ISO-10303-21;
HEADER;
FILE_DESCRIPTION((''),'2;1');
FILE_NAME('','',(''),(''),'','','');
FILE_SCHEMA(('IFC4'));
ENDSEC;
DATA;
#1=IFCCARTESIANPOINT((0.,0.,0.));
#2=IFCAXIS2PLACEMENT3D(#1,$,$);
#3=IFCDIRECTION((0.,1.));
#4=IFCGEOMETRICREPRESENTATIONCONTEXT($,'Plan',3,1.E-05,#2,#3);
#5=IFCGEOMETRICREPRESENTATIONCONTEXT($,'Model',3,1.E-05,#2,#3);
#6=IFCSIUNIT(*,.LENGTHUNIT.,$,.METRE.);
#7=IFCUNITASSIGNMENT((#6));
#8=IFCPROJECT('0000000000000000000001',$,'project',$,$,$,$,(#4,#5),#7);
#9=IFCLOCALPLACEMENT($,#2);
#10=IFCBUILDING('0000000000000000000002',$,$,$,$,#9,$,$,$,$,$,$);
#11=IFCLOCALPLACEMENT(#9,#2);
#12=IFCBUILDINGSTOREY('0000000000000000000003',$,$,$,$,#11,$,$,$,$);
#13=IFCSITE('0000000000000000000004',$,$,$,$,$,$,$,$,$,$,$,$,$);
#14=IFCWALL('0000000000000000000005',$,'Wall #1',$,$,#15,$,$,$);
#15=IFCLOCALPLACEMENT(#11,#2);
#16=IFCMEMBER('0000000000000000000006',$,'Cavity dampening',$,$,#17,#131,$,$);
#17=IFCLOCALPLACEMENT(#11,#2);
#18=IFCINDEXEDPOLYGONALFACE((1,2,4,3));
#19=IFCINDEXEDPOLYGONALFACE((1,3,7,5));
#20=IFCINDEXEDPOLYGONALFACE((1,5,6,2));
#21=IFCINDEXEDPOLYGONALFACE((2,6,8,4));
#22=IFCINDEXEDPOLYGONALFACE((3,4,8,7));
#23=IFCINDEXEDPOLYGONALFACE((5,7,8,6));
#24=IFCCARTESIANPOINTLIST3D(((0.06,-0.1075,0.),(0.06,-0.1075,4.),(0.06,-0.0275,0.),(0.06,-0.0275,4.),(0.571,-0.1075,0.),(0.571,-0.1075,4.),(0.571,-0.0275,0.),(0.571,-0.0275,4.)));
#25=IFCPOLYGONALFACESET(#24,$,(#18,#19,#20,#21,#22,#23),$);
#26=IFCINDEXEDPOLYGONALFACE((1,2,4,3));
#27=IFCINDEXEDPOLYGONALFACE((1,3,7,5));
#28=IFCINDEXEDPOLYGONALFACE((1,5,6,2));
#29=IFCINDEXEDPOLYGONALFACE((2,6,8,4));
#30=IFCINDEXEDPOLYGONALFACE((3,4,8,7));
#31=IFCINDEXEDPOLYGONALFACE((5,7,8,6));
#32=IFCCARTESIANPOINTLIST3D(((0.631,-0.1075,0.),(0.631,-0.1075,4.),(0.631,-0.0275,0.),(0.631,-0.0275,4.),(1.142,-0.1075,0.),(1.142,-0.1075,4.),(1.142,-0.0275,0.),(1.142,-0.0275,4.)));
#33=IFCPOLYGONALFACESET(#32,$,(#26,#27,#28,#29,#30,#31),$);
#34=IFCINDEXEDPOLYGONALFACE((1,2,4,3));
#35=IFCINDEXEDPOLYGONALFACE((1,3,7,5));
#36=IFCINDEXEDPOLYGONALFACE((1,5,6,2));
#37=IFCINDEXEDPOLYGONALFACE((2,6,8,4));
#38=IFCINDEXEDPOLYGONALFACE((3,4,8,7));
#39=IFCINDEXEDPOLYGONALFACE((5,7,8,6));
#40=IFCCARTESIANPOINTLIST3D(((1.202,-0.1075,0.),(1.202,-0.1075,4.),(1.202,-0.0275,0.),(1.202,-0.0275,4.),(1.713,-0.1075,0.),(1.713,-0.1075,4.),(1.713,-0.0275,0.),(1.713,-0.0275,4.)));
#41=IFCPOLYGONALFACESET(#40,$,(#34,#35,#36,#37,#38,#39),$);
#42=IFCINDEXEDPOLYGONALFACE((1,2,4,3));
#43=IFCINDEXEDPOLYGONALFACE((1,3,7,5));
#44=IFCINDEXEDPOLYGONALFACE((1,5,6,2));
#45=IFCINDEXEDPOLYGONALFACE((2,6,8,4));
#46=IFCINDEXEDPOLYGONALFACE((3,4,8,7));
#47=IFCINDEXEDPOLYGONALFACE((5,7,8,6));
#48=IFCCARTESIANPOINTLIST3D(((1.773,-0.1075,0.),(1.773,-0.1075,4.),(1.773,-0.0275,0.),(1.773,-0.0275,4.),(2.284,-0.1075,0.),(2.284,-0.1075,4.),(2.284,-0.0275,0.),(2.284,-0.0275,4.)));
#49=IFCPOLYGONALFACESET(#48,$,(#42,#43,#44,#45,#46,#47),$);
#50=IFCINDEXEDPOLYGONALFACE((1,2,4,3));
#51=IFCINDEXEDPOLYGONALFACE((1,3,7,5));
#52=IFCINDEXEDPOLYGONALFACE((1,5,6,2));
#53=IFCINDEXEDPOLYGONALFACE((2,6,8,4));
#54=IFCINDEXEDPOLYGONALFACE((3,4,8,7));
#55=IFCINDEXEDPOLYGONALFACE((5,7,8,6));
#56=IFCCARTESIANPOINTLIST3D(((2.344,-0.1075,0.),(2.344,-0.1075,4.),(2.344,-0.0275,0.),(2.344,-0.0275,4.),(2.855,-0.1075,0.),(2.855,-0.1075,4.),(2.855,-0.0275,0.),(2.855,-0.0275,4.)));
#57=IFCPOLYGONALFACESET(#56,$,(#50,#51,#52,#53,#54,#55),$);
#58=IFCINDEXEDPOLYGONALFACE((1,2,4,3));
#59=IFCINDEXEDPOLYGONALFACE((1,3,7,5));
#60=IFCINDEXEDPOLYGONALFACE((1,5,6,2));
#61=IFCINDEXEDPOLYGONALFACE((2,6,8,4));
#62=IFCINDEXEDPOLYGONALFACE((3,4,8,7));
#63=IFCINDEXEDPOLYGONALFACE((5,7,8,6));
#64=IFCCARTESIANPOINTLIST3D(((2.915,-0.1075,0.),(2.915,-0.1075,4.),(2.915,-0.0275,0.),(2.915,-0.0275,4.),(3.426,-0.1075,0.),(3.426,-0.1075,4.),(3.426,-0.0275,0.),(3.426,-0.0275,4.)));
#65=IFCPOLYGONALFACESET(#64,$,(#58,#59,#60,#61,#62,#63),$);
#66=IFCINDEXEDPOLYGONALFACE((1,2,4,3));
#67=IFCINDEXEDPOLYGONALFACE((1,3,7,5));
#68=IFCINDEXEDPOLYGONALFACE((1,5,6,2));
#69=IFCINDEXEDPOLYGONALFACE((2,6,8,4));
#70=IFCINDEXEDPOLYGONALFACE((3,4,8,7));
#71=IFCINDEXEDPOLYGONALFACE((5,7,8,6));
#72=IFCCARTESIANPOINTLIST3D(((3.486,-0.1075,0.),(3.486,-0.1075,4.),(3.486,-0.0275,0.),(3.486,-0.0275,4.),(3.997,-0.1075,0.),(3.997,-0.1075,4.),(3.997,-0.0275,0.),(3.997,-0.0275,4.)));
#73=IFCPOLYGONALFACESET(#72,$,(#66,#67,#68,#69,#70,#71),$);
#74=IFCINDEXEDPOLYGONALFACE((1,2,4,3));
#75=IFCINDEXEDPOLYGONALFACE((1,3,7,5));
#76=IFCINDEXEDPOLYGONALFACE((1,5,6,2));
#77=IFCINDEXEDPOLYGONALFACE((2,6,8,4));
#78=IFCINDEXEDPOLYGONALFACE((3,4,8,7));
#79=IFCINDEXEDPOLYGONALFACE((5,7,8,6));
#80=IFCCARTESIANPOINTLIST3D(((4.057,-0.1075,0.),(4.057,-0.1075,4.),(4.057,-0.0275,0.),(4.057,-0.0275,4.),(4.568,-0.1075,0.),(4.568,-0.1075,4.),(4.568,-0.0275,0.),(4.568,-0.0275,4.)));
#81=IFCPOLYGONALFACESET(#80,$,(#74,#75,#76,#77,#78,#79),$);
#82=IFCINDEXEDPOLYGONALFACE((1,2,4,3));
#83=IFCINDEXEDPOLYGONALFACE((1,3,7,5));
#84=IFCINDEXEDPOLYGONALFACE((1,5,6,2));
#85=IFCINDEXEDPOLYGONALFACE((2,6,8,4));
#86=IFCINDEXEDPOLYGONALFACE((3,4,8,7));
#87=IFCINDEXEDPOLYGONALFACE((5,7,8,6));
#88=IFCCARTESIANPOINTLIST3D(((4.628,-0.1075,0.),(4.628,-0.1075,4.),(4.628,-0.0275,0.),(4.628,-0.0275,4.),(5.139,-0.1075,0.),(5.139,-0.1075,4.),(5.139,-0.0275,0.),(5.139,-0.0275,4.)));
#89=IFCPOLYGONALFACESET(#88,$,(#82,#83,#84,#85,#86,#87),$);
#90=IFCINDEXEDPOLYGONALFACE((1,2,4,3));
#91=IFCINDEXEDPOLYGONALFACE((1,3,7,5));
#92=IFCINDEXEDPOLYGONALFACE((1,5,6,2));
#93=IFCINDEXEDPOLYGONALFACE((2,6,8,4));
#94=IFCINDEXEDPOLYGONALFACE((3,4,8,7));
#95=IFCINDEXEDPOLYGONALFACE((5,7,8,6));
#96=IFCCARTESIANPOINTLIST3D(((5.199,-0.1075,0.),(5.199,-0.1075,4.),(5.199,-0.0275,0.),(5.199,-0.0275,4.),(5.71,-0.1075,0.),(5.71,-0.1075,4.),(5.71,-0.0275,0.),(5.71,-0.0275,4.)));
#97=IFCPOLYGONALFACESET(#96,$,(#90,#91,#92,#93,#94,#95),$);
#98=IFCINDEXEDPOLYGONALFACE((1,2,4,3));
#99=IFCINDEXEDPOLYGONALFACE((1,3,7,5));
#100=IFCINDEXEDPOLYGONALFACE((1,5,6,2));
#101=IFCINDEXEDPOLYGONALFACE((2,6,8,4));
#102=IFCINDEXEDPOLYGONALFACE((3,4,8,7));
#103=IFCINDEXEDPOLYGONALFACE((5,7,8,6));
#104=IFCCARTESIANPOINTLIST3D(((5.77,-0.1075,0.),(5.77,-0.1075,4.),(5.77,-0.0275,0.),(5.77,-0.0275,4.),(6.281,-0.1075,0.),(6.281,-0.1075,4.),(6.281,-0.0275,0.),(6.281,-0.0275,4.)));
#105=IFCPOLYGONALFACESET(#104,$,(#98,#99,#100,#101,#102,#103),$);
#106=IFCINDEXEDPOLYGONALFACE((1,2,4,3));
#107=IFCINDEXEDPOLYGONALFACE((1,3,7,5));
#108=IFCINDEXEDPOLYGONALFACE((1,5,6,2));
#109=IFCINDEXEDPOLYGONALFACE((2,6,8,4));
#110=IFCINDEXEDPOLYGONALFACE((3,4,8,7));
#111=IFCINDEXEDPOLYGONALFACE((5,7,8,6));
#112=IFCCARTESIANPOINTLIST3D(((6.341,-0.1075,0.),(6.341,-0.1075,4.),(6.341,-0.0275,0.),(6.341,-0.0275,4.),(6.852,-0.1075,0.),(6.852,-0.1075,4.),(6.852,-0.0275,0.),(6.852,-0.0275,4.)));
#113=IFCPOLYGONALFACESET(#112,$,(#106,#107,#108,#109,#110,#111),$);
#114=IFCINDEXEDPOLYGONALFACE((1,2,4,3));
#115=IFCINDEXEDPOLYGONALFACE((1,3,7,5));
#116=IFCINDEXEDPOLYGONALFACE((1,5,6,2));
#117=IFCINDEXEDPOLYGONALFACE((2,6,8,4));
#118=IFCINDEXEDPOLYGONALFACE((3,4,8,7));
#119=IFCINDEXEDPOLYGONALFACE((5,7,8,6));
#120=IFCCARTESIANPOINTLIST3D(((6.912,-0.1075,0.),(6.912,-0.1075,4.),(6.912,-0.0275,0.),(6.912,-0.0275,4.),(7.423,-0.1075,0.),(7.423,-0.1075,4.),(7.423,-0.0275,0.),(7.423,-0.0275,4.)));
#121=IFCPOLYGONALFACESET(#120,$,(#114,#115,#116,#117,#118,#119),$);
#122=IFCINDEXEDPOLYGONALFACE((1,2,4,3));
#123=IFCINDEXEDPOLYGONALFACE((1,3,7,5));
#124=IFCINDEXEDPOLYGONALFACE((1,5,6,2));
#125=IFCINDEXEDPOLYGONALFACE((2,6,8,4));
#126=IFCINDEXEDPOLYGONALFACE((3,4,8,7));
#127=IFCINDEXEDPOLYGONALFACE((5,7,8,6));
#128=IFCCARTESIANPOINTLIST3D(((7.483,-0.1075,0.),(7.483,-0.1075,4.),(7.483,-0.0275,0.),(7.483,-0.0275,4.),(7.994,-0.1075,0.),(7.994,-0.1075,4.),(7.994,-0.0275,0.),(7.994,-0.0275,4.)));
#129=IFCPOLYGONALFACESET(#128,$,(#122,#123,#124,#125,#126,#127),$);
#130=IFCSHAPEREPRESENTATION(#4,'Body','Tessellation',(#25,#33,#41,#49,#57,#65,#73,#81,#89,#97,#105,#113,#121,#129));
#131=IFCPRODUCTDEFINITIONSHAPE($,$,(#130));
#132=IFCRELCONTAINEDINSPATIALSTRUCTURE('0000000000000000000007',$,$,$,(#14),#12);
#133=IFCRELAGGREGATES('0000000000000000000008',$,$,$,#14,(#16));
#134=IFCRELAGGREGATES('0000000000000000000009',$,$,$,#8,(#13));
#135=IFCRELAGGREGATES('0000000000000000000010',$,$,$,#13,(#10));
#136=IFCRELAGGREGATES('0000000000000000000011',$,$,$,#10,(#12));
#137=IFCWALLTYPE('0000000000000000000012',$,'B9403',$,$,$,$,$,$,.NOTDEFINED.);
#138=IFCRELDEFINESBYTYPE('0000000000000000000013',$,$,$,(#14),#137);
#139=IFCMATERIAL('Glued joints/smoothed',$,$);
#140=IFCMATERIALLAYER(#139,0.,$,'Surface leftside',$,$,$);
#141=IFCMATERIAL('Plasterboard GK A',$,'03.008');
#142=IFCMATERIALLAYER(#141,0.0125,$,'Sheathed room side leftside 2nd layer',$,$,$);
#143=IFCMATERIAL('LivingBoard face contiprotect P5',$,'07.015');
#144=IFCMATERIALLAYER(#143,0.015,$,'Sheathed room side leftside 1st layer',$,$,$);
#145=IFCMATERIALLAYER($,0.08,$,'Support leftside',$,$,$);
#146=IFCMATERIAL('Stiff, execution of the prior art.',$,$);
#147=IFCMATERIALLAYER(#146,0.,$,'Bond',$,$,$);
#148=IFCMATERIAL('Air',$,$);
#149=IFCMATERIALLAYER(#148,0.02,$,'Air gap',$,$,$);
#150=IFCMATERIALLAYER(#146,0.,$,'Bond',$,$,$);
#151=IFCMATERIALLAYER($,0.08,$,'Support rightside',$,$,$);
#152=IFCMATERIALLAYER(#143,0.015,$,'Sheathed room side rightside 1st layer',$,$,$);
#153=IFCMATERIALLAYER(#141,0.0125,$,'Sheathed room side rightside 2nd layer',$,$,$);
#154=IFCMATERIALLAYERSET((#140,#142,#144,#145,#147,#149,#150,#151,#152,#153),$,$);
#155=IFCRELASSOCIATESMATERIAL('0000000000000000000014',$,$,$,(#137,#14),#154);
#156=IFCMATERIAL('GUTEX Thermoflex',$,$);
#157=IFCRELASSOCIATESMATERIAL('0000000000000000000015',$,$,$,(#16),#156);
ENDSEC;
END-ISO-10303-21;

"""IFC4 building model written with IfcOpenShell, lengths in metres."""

from ifc_helpers import new_model, si_unit, direction, frame, frame_2d, origin, place, context, project, spatial, rectangle, extrude, material, layer, layer_set, type_object, element, aggregate, save


model = new_model("IFC4")

# Units and contexts
plan_context = context("Plan", 3, precision=1e-05, world=origin(), true_north=direction((0.0, 1.0)))
model_context = context("Model", 3, precision=1e-05, world=origin(), true_north=direction((0.0, 1.0)))
ifc_project = project(units=[si_unit("LENGTHUNIT", "METRE")], contexts=[plan_context, model_context])

# Site, building, storey
site = spatial("IfcSite", under=ifc_project)
building_placement = place(None, origin())
building = spatial("IfcBuilding", under=site, at=building_placement)
storey_placement = place(building_placement, origin())
storey = spatial("IfcBuildingStorey", under=building, at=storey_placement)

# Wall, member
ifc_material_1 = material(Name="Glued joints/smoothed")
ifc_layer_1 = layer(ifc_material_1, 0.0, Name="Surface leftside")
ifc_material_2 = material(Name="Plasterboard GK A", Category="03.008")
ifc_layer_2 = layer(ifc_material_2, 0.0125, Name="Sheathed room side leftside 2nd layer")
ifc_material_3 = material(Name="LivingBoard face contiprotect P5", Category="07.015")
ifc_layer_3 = layer(ifc_material_3, 0.015, Name="Sheathed room side leftside 1st layer")
ifc_layer_4 = layer(None, 0.08, Name="Support leftside")
ifc_material_4 = material(Name="Stiff, execution of the prior art.")
ifc_layer_5 = layer(ifc_material_4, 0.0, Name="Bond")
ifc_material_5 = material(Name="Air")
ifc_layer_6 = layer(ifc_material_5, 0.02, Name="Air gap")
ifc_layer_7 = layer(ifc_material_4, 0.0, Name="Bond")
ifc_layer_8 = layer(None, 0.08, Name="Support rightside")
ifc_layer_9 = layer(ifc_material_3, 0.015, Name="Sheathed room side rightside 1st layer")
ifc_layer_10 = layer(ifc_material_2, 0.0125, Name="Sheathed room side rightside 2nd layer")
ifc_layer_set = layer_set([ifc_layer_1, ifc_layer_2, ifc_layer_3, ifc_layer_4, ifc_layer_5, ifc_layer_6, ifc_layer_7, ifc_layer_8, ifc_layer_9, ifc_layer_10])
wall_type = type_object("IfcWallType", Name="B9403", PredefinedType="NOTDEFINED", material=ifc_layer_set)
wall_placement = place(None, frame((0.0, 0.0, 0.0), z_axis=(0.0, -1.0, 0.0), x_axis=(1.0, 0.0, 0.0)))
wall = element("IfcWall", 1, at=wall_placement, inside=storey, type_object=wall_type, material=ifc_layer_set, Name="Wall #1")
ifc_material_6 = material(Name="GUTEX Thermoflex")
member_1_placement = place(wall_placement, origin())
member_1 = element("IfcMember", 2, at=member_1_placement, material=ifc_material_6, Name="Cavity dampening", context=plan_context, shape_type="SweptSolid", body=[
    extrude(rectangle(XDim=0.511, YDim=0.08, at=frame_2d((0.2555, 0.04), x_axis=(1.0, 0.0))), frame((0.06, 4.0, 0.0275), z_axis=(0.0, -1.0, 0.0), x_axis=(1.0, 0.0, 0.0)), (0.0, 0.0, 1.0), 4.0),
    extrude(rectangle(XDim=0.511, YDim=0.08, at=frame_2d((0.2555, 0.04), x_axis=(1.0, 0.0))), frame((0.631, 4.0, 0.0275), z_axis=(0.0, -1.0, 0.0), x_axis=(1.0, 0.0, 0.0)), (0.0, 0.0, 1.0), 4.0),
    extrude(rectangle(XDim=0.511, YDim=0.08, at=frame_2d((0.2555, 0.04), x_axis=(1.0, 0.0))), frame((1.202, 4.0, 0.0275), z_axis=(0.0, -1.0, 0.0), x_axis=(1.0, 0.0, 0.0)), (0.0, 0.0, 1.0), 4.0),
    extrude(rectangle(XDim=0.511, YDim=0.08, at=frame_2d((0.2555, 0.04), x_axis=(1.0, 0.0))), frame((1.773, 4.0, 0.0275), z_axis=(0.0, -1.0, 0.0), x_axis=(1.0, 0.0, 0.0)), (0.0, 0.0, 1.0), 4.0),
    extrude(rectangle(XDim=0.511, YDim=0.08, at=frame_2d((0.2555, 0.04), x_axis=(1.0, 0.0))), frame((2.344, 4.0, 0.0275), z_axis=(0.0, -1.0, 0.0), x_axis=(1.0, 0.0, 0.0)), (0.0, 0.0, 1.0), 4.0),
    extrude(rectangle(XDim=0.511, YDim=0.08, at=frame_2d((0.2555, 0.04), x_axis=(1.0, 0.0))), frame((2.915, 4.0, 0.0275), z_axis=(0.0, -1.0, 0.0), x_axis=(1.0, 0.0, 0.0)), (0.0, 0.0, 1.0), 4.0),
    extrude(rectangle(XDim=0.511, YDim=0.08, at=frame_2d((0.2555, 0.04), x_axis=(1.0, 0.0))), frame((3.486, 4.0, 0.0275), z_axis=(0.0, -1.0, 0.0), x_axis=(1.0, 0.0, 0.0)), (0.0, 0.0, 1.0), 4.0),
    extrude(rectangle(XDim=0.511, YDim=0.08, at=frame_2d((0.2555, 0.04), x_axis=(1.0, 0.0))), frame((4.057, 4.0, 0.0275), z_axis=(0.0, -1.0, 0.0), x_axis=(1.0, 0.0, 0.0)), (0.0, 0.0, 1.0), 4.0),
    extrude(rectangle(XDim=0.511, YDim=0.08, at=frame_2d((0.2555, 0.04), x_axis=(1.0, 0.0))), frame((4.628, 4.0, 0.0275), z_axis=(0.0, -1.0, 0.0), x_axis=(1.0, 0.0, 0.0)), (0.0, 0.0, 1.0), 4.0),
    extrude(rectangle(XDim=0.511, YDim=0.08, at=frame_2d((0.2555, 0.04), x_axis=(1.0, 0.0))), frame((5.199, 4.0, 0.0275), z_axis=(0.0, -1.0, 0.0), x_axis=(1.0, 0.0, 0.0)), (0.0, 0.0, 1.0), 4.0),
    extrude(rectangle(XDim=0.511, YDim=0.08, at=frame_2d((0.2555, 0.04), x_axis=(1.0, 0.0))), frame((5.77, 4.0, 0.0275), z_axis=(0.0, -1.0, 0.0), x_axis=(1.0, 0.0, 0.0)), (0.0, 0.0, 1.0), 4.0),
    extrude(rectangle(XDim=0.511, YDim=0.08, at=frame_2d((0.2555, 0.04), x_axis=(1.0, 0.0))), frame((6.341, 4.0, 0.0275), z_axis=(0.0, -1.0, 0.0), x_axis=(1.0, 0.0, 0.0)), (0.0, 0.0, 1.0), 4.0),
    extrude(rectangle(XDim=0.511, YDim=0.08, at=frame_2d((0.2555, 0.04), x_axis=(1.0, 0.0))), frame((6.912, 4.0, 0.0275), z_axis=(0.0, -1.0, 0.0), x_axis=(1.0, 0.0, 0.0)), (0.0, 0.0, 1.0), 4.0),
    extrude(rectangle(XDim=0.511, YDim=0.08, at=frame_2d((0.2555, 0.04), x_axis=(1.0, 0.0))), frame((7.483, 4.0, 0.0275), z_axis=(0.0, -1.0, 0.0), x_axis=(1.0, 0.0, 0.0)), (0.0, 0.0, 1.0), 4.0),
])
aggregate(wall, [member_1])

save(model, "model.ifc")
